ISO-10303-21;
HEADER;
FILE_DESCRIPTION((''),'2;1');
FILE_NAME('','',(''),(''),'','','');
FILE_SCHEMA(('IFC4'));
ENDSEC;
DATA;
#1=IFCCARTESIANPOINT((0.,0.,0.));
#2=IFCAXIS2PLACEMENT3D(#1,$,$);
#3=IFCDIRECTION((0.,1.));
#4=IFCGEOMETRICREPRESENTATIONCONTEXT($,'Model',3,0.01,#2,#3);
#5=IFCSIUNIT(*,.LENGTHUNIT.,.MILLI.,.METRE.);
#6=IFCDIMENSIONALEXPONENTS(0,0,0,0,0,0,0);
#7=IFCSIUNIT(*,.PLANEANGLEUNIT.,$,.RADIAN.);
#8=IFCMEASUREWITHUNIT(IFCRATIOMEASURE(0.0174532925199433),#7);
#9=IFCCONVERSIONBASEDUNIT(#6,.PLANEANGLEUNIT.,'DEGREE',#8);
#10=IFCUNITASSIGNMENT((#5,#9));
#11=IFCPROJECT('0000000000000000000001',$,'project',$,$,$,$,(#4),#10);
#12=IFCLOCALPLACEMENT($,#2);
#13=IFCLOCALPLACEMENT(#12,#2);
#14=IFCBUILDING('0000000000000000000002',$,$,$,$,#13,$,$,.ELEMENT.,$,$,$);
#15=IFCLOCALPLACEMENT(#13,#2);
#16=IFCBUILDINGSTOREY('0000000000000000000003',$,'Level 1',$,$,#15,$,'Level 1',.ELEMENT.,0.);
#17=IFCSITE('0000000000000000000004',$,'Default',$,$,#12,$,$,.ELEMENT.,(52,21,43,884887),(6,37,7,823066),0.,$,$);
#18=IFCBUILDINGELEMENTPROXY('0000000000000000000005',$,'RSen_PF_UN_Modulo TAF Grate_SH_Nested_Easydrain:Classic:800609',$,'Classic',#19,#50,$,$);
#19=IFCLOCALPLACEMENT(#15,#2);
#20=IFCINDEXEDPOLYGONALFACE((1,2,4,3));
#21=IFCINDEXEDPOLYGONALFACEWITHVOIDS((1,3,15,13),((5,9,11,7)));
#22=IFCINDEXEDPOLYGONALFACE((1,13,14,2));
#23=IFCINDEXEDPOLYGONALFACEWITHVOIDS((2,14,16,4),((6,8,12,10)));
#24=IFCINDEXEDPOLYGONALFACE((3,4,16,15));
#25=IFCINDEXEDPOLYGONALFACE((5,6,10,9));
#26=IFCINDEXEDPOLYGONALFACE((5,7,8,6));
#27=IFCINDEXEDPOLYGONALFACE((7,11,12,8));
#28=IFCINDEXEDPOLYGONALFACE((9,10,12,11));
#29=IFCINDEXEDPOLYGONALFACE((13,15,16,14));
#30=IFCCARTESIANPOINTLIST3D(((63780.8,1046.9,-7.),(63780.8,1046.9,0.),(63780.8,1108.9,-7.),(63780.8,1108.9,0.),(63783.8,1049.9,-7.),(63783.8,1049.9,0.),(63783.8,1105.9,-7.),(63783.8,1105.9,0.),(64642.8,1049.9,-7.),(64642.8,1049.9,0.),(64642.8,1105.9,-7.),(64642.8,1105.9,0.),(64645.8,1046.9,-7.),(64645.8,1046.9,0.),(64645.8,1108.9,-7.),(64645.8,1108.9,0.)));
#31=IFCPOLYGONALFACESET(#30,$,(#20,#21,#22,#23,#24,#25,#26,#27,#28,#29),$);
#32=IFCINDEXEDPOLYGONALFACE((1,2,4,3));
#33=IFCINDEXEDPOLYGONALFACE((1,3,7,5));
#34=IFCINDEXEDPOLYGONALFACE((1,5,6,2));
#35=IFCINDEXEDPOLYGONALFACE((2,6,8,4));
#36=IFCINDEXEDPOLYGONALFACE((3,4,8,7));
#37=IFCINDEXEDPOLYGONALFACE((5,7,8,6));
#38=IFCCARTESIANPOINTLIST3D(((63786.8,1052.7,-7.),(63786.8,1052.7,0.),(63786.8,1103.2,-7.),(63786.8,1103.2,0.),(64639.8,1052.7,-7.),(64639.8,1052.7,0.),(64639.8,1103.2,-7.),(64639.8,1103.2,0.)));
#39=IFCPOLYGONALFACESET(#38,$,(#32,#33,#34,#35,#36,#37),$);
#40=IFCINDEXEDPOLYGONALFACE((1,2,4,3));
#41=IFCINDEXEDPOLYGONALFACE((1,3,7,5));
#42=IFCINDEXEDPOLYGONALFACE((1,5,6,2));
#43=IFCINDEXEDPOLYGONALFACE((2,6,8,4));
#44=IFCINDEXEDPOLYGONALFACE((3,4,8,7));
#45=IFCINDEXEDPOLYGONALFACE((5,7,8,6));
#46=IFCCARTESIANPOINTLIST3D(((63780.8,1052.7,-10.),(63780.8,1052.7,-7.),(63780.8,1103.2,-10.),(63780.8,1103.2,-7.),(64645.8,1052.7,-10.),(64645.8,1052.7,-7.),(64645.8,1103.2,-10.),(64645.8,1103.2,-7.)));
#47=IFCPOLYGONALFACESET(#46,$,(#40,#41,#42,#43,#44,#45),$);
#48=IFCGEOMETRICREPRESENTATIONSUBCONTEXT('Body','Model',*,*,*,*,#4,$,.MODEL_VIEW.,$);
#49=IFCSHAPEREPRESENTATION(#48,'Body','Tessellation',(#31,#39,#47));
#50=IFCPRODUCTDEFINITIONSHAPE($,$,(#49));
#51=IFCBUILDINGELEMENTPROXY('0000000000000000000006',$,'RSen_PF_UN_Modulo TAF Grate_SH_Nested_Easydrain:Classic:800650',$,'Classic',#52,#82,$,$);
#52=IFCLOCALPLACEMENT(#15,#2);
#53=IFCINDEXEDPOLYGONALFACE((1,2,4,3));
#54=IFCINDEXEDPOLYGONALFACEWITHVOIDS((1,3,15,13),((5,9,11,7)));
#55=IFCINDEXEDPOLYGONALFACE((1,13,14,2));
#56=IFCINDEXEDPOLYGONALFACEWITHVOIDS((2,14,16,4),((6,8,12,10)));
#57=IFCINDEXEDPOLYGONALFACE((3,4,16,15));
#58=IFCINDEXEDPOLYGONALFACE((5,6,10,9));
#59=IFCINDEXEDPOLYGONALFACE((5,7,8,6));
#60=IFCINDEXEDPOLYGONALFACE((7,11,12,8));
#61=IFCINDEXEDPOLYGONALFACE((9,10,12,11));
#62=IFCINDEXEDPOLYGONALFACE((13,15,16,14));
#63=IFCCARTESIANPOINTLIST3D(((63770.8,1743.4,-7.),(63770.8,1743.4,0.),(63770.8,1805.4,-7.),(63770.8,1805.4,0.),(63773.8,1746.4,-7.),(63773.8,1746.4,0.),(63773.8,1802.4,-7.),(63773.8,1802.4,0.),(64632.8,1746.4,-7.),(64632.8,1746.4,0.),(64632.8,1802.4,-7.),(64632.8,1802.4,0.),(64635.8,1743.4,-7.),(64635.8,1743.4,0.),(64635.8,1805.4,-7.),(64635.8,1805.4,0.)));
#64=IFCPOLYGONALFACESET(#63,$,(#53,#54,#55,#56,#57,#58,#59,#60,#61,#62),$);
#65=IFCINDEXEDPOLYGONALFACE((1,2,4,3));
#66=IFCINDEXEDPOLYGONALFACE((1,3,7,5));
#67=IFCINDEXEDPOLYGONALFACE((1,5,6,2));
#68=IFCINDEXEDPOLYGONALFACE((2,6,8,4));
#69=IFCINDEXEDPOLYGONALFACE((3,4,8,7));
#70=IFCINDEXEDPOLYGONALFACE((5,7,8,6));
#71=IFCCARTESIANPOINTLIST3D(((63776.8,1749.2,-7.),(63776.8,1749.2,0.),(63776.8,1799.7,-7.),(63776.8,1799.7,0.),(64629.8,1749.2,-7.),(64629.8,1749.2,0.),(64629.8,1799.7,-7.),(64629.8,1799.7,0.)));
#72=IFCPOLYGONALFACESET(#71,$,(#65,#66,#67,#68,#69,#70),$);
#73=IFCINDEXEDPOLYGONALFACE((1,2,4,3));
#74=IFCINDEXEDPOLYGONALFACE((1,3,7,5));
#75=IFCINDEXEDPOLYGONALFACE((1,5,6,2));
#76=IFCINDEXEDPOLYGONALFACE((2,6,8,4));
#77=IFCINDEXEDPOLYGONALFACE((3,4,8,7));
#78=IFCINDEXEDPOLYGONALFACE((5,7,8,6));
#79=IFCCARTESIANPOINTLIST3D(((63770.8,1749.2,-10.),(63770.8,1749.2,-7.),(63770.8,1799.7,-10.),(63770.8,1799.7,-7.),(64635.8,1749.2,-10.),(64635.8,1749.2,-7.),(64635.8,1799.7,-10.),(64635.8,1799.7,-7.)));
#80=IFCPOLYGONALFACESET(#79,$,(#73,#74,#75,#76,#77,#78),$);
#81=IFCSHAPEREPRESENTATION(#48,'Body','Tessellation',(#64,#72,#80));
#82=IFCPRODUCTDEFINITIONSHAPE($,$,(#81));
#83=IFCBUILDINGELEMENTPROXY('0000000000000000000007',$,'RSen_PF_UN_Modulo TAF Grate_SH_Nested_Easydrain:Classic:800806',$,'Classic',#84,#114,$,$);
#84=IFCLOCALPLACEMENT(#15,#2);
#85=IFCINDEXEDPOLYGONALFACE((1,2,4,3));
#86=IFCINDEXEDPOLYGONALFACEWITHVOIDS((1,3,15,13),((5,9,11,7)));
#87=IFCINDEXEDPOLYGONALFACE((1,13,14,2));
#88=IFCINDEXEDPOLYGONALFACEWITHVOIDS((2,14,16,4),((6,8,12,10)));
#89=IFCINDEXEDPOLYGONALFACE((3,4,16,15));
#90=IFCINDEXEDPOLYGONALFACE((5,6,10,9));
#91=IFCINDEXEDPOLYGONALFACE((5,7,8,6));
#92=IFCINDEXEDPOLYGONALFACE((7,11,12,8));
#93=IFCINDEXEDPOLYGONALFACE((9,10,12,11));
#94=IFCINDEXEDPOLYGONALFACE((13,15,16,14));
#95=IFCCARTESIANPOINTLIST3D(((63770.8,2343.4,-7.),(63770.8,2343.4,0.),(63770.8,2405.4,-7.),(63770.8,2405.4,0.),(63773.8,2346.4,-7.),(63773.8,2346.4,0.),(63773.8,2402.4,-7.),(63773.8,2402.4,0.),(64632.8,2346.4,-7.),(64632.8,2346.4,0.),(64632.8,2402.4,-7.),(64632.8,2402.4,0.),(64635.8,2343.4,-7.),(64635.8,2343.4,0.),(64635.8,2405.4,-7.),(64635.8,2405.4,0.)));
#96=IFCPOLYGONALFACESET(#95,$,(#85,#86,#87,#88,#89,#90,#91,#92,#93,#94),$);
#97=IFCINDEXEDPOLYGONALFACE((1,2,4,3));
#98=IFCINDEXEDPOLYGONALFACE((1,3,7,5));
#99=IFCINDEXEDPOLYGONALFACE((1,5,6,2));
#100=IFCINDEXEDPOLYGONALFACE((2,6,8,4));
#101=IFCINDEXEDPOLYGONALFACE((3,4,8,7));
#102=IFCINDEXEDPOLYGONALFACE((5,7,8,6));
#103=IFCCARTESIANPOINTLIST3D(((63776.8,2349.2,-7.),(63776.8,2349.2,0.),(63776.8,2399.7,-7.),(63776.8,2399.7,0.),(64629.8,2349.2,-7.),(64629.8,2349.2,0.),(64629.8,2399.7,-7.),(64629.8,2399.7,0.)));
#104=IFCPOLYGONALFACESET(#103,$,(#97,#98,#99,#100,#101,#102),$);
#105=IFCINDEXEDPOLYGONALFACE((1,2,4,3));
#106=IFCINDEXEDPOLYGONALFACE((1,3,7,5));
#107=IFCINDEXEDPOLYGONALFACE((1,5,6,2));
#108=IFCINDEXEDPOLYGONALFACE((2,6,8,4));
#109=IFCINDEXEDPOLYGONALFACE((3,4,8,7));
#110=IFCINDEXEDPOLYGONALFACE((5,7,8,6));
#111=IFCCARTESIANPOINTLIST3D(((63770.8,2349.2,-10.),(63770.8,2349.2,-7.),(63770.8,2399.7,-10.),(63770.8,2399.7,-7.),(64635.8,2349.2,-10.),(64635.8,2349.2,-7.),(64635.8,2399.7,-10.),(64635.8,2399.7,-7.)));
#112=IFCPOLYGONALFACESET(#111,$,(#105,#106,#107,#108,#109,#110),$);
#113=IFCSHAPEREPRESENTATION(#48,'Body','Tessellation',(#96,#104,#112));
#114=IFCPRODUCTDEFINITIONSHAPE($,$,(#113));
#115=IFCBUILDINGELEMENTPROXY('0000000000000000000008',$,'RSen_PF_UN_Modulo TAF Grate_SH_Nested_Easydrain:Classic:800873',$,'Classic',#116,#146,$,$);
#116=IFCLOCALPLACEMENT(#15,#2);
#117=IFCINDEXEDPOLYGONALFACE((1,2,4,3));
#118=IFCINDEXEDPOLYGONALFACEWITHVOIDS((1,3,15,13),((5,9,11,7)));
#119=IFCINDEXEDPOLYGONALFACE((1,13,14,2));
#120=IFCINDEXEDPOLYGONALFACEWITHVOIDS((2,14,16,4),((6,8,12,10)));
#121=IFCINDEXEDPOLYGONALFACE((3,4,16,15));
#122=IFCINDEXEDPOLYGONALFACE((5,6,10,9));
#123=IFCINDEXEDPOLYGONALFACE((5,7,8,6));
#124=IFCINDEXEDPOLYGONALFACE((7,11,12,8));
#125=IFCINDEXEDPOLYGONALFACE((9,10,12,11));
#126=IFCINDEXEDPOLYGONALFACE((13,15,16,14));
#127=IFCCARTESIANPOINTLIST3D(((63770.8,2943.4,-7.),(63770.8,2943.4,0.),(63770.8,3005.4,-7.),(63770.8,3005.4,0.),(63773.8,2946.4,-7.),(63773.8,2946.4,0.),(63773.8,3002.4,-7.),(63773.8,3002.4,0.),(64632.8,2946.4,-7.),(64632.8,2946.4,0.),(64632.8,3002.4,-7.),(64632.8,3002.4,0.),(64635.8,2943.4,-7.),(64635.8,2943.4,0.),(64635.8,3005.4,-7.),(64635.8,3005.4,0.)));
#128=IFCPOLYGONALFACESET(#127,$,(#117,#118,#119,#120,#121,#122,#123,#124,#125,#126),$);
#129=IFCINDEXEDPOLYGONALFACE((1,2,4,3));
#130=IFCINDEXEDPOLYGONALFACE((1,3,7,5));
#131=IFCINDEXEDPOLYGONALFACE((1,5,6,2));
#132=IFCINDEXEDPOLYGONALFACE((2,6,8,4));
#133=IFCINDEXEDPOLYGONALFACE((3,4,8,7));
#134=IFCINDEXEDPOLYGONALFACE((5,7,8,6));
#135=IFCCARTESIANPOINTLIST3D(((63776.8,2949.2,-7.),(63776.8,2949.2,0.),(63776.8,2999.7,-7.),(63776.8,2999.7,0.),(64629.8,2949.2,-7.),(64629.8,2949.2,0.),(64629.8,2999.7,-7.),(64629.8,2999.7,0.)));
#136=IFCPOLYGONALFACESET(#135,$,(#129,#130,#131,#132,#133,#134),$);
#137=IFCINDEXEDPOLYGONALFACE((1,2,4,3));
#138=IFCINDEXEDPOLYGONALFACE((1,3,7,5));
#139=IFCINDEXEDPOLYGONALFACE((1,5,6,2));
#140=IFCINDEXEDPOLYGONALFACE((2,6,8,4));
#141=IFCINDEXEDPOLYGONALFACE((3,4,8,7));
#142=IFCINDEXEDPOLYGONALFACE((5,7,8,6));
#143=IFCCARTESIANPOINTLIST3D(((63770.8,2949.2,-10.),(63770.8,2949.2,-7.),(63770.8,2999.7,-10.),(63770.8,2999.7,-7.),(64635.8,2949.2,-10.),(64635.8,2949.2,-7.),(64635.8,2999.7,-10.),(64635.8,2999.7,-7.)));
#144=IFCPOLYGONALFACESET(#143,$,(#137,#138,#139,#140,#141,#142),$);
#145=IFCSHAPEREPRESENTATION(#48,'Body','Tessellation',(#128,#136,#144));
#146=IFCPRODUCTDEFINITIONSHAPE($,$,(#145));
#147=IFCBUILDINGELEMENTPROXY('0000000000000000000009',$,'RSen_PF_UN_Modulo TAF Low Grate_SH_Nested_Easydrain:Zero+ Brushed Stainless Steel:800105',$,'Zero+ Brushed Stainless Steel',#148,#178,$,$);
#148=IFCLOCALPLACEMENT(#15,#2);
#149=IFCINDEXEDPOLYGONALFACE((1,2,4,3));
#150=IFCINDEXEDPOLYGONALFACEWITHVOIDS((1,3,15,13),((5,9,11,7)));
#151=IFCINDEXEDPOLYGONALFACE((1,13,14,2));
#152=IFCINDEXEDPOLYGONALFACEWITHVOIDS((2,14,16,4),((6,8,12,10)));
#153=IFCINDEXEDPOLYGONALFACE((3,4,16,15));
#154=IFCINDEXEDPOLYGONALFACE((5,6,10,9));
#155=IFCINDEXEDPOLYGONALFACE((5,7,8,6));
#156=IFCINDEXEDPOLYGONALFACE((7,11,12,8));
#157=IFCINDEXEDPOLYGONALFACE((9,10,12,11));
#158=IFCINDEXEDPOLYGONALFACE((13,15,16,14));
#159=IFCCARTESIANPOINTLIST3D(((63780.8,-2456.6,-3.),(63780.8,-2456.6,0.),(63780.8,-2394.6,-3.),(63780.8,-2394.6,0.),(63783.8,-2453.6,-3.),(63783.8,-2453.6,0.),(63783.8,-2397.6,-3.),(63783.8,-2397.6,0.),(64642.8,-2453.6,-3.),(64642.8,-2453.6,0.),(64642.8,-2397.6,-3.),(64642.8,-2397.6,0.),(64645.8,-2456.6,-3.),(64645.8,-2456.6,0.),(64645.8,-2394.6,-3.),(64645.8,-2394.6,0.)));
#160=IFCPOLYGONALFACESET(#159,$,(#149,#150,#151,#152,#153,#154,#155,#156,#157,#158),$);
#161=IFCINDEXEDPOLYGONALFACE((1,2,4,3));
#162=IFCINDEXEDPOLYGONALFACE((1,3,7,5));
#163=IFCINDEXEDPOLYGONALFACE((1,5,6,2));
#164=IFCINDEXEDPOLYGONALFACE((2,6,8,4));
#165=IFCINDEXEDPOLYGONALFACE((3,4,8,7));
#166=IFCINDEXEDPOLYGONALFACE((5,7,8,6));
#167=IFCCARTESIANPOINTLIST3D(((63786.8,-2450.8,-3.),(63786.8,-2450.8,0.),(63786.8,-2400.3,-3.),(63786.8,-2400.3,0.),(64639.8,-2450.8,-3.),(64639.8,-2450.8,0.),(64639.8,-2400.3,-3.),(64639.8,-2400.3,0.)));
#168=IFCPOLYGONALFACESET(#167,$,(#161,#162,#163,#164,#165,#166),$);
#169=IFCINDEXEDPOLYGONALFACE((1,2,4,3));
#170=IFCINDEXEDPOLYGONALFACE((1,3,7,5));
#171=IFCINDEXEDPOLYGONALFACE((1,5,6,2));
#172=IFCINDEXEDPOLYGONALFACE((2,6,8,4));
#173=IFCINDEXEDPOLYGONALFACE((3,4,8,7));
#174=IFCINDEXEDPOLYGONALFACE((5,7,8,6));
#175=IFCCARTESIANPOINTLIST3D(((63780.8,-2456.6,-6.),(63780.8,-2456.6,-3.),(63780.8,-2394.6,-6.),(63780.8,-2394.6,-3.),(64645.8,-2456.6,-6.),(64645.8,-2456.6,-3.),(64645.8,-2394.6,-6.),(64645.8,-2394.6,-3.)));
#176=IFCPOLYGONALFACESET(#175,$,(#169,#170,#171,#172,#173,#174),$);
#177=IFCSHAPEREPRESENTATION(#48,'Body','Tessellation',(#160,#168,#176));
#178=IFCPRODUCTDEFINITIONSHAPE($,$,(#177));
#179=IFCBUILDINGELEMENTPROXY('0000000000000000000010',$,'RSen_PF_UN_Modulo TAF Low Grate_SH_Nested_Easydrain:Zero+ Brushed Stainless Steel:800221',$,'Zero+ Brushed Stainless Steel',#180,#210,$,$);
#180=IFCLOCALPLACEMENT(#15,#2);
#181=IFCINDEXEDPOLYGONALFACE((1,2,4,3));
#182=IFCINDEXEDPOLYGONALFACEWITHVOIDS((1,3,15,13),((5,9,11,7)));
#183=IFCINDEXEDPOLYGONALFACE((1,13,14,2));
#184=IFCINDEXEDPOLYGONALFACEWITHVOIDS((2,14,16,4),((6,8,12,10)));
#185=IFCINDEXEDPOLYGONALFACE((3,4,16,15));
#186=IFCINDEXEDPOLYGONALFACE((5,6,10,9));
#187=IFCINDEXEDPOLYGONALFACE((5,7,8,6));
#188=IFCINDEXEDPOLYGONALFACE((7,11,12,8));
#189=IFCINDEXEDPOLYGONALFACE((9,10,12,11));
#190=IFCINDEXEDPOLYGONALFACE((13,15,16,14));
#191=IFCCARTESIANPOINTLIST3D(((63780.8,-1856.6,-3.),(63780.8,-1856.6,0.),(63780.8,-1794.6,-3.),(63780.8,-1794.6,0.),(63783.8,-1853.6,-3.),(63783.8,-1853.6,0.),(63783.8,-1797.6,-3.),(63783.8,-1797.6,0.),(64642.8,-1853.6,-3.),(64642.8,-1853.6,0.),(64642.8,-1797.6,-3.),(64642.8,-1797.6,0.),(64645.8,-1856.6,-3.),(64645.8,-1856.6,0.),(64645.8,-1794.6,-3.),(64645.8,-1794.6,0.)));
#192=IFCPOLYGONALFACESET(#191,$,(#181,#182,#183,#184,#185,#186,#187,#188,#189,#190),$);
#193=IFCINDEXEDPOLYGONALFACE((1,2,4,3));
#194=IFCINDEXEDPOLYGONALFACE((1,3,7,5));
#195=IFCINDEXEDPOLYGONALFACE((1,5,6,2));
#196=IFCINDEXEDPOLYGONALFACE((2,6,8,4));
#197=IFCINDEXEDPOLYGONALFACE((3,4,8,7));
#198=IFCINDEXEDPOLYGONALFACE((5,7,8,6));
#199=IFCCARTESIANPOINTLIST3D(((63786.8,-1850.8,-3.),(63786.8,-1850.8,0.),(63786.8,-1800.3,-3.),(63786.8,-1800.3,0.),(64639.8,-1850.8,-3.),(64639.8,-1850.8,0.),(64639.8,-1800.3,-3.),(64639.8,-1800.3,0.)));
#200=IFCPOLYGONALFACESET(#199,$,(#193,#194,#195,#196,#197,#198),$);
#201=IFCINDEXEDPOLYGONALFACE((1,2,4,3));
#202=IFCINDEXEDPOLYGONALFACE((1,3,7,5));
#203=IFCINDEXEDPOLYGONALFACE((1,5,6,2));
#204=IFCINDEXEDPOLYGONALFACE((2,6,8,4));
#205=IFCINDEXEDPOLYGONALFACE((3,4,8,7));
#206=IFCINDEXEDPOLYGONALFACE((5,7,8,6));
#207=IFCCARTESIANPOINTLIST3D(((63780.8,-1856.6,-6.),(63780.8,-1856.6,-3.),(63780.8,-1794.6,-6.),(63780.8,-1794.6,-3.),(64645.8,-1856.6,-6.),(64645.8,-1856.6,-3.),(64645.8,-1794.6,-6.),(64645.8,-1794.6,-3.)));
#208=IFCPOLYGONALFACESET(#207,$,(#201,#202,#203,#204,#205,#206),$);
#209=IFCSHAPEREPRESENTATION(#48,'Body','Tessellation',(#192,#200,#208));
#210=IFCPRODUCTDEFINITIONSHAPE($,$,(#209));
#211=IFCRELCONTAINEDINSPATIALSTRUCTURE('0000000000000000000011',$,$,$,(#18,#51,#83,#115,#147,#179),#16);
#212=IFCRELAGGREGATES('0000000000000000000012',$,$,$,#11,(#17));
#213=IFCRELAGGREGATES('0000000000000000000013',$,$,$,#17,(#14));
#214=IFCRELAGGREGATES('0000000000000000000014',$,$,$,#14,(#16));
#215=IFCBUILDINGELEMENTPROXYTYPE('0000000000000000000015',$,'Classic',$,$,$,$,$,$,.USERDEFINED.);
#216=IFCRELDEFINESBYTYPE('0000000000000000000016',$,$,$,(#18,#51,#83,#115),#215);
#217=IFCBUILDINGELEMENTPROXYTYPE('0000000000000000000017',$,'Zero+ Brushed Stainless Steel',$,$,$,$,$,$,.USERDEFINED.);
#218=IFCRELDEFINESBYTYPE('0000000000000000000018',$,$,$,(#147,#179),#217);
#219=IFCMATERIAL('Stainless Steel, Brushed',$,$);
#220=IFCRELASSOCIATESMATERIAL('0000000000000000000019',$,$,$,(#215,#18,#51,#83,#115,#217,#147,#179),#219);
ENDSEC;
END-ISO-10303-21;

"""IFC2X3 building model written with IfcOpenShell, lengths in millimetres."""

from ifc_helpers import new_model, entity, si_unit, converted_unit, direction, frame, frame_2d, origin, origin_2d_with_axis, place, context, subcontext, project, spatial, polyline, rectangle, outline, extrude, source, transform, mapped, material, type_object, type_shapes, element, save


model = new_model("IFC2X3")

# Units and contexts
model_context = context("Model", 3, precision=0.01, world=origin(), true_north=direction((0.0, 1.0)))
body_context = subcontext(model_context, "Body", "Model", "MODEL_VIEW")
ifc_project = project(units=[si_unit("LENGTHUNIT", "METRE", prefix="MILLI"), converted_unit("PLANEANGLEUNIT", "DEGREE", entity("IfcRatioMeasure", 0.0174532925199433), si_unit("PLANEANGLEUNIT", "RADIAN"), dimensions=[0, 0, 0, 0, 0, 0, 0])], contexts=[model_context])

# Site, building, storey
site_placement = place(None, origin())
site = spatial("IfcSite", under=ifc_project, at=site_placement, Name="Default", CompositionType="ELEMENT", RefLatitude=(52, 21, 43, 884887), RefLongitude=(6, 37, 7, 823066), RefElevation=0.0)
building_placement = place(site_placement, origin())
building = spatial("IfcBuilding", under=site, at=building_placement, CompositionType="ELEMENT")
storey_placement = place(building_placement, origin())
storey = spatial("IfcBuildingStorey", under=building, at=storey_placement, Name="Level 1", LongName="Level 1", CompositionType="ELEMENT", Elevation=0.0)

# Shared definitions
ifc_material_1 = material(Name="Stainless Steel, Brushed")

# Building element proxies
building_element_proxy_type_1 = type_object("IfcBuildingElementProxyType", Name="Classic", PredefinedType="USERDEFINED", material=ifc_material_1)
shared_shape_1 = source(origin(), body_context, "Body", "SweptSolid", [
    extrude(outline(polyline([(-432.5, -31.0), (432.5, -31.0), (432.5, 31.0), (-432.5, 31.0), (-432.5, -31.0)]), holes=[polyline([(-429.5, -28.0), (-429.5, 28.0), (429.5, 28.0), (429.5, -28.0), (-429.5, -28.0)])]), frame((0.0, 0.0, 0.0), z_axis=(0.0, 0.0, 1.0), x_axis=(-1.0, 0.0, 0.0)), (0.0, 0.0, 1.0), 7.0),
    extrude(rectangle(XDim=853.0, YDim=50.5, at=frame_2d((0.0, 0.0), x_axis=(1.0, 0.0))), frame((0.0, 0.0, 0.0), z_axis=(0.0, 0.0, 1.0), x_axis=(-1.0, 0.0, 0.0)), (0.0, 0.0, 1.0), 7.0),
    extrude(rectangle(XDim=865.0, YDim=50.5, at=origin_2d_with_axis()), frame((0.0, 0.0, -3.0), z_axis=(0.0, 0.0, 1.0), x_axis=(-1.0, 0.0, 0.0)), (0.0, 0.0, 1.0), 3.0),
])
type_shapes(building_element_proxy_type_1, [shared_shape_1])
for number, where, name in (
    (1, (64213.3, 1077.9, -7.0), "RSen_PF_UN_Modulo TAF Grate_SH_Nested_Easydrain:Classic:800609"),
    (2, (64203.3, 1774.4, -7.0), "RSen_PF_UN_Modulo TAF Grate_SH_Nested_Easydrain:Classic:800650"),
    (3, (64203.3, 2374.4, -7.0), "RSen_PF_UN_Modulo TAF Grate_SH_Nested_Easydrain:Classic:800806"),
    (4, (64203.3, 2974.4, -7.0), "RSen_PF_UN_Modulo TAF Grate_SH_Nested_Easydrain:Classic:800873"),
):
    element("IfcBuildingElementProxy", number, at=place(storey_placement, frame(where)), inside=storey, type_object=building_element_proxy_type_1, material=ifc_material_1, Name=name, ObjectType="Classic", context=body_context, shape_type="MappedRepresentation", body=[
        mapped(shared_shape_1, transform((0.0, 0.0, 0.0), scale=1.0)),
    ])
building_element_proxy_type_2 = type_object("IfcBuildingElementProxyType", Name="Zero+ Brushed Stainless Steel", PredefinedType="USERDEFINED", material=ifc_material_1)
shared_shape_2 = source(origin(), body_context, "Body", "SweptSolid", [
    extrude(outline(polyline([(-432.5, -31.0), (432.5, -31.0), (432.5, 31.0), (-432.5, 31.0), (-432.5, -31.0)]), holes=[polyline([(-429.5, -28.0), (-429.5, 28.0), (429.5, 28.0), (429.5, -28.0), (-429.5, -28.0)])]), frame((0.0, 0.0, 0.0), z_axis=(0.0, 0.0, 1.0), x_axis=(-1.0, 0.0, 0.0)), (0.0, 0.0, 1.0), 3.0),
    extrude(rectangle(XDim=853.0, YDim=50.5, at=frame_2d((0.0, 0.0), x_axis=(1.0, 0.0))), frame((0.0, 0.0, 0.0), z_axis=(0.0, 0.0, 1.0), x_axis=(-1.0, 0.0, 0.0)), (0.0, 0.0, 1.0), 3.0),
    extrude(rectangle(XDim=865.0, YDim=62.0, at=origin_2d_with_axis()), frame((0.0, 0.0, -3.0), z_axis=(0.0, 0.0, 1.0), x_axis=(-1.0, 0.0, 0.0)), (0.0, 0.0, 1.0), 3.0),
])
type_shapes(building_element_proxy_type_2, [shared_shape_2])
for number, where, name in (
    (5, (64213.3, -2425.6, -3.0), "RSen_PF_UN_Modulo TAF Low Grate_SH_Nested_Easydrain:Zero+ Brushed Stainless Steel:800105"),
    (6, (64213.3, -1825.6, -3.0), "RSen_PF_UN_Modulo TAF Low Grate_SH_Nested_Easydrain:Zero+ Brushed Stainless Steel:800221"),
):
    element("IfcBuildingElementProxy", number, at=place(storey_placement, frame(where)), inside=storey, type_object=building_element_proxy_type_2, material=ifc_material_1, Name=name, ObjectType="Zero+ Brushed Stainless Steel", context=body_context, shape_type="MappedRepresentation", body=[
        mapped(shared_shape_2, transform((0.0, 0.0, 0.0), scale=1.0)),
    ])

save(model, "model.ifc")
